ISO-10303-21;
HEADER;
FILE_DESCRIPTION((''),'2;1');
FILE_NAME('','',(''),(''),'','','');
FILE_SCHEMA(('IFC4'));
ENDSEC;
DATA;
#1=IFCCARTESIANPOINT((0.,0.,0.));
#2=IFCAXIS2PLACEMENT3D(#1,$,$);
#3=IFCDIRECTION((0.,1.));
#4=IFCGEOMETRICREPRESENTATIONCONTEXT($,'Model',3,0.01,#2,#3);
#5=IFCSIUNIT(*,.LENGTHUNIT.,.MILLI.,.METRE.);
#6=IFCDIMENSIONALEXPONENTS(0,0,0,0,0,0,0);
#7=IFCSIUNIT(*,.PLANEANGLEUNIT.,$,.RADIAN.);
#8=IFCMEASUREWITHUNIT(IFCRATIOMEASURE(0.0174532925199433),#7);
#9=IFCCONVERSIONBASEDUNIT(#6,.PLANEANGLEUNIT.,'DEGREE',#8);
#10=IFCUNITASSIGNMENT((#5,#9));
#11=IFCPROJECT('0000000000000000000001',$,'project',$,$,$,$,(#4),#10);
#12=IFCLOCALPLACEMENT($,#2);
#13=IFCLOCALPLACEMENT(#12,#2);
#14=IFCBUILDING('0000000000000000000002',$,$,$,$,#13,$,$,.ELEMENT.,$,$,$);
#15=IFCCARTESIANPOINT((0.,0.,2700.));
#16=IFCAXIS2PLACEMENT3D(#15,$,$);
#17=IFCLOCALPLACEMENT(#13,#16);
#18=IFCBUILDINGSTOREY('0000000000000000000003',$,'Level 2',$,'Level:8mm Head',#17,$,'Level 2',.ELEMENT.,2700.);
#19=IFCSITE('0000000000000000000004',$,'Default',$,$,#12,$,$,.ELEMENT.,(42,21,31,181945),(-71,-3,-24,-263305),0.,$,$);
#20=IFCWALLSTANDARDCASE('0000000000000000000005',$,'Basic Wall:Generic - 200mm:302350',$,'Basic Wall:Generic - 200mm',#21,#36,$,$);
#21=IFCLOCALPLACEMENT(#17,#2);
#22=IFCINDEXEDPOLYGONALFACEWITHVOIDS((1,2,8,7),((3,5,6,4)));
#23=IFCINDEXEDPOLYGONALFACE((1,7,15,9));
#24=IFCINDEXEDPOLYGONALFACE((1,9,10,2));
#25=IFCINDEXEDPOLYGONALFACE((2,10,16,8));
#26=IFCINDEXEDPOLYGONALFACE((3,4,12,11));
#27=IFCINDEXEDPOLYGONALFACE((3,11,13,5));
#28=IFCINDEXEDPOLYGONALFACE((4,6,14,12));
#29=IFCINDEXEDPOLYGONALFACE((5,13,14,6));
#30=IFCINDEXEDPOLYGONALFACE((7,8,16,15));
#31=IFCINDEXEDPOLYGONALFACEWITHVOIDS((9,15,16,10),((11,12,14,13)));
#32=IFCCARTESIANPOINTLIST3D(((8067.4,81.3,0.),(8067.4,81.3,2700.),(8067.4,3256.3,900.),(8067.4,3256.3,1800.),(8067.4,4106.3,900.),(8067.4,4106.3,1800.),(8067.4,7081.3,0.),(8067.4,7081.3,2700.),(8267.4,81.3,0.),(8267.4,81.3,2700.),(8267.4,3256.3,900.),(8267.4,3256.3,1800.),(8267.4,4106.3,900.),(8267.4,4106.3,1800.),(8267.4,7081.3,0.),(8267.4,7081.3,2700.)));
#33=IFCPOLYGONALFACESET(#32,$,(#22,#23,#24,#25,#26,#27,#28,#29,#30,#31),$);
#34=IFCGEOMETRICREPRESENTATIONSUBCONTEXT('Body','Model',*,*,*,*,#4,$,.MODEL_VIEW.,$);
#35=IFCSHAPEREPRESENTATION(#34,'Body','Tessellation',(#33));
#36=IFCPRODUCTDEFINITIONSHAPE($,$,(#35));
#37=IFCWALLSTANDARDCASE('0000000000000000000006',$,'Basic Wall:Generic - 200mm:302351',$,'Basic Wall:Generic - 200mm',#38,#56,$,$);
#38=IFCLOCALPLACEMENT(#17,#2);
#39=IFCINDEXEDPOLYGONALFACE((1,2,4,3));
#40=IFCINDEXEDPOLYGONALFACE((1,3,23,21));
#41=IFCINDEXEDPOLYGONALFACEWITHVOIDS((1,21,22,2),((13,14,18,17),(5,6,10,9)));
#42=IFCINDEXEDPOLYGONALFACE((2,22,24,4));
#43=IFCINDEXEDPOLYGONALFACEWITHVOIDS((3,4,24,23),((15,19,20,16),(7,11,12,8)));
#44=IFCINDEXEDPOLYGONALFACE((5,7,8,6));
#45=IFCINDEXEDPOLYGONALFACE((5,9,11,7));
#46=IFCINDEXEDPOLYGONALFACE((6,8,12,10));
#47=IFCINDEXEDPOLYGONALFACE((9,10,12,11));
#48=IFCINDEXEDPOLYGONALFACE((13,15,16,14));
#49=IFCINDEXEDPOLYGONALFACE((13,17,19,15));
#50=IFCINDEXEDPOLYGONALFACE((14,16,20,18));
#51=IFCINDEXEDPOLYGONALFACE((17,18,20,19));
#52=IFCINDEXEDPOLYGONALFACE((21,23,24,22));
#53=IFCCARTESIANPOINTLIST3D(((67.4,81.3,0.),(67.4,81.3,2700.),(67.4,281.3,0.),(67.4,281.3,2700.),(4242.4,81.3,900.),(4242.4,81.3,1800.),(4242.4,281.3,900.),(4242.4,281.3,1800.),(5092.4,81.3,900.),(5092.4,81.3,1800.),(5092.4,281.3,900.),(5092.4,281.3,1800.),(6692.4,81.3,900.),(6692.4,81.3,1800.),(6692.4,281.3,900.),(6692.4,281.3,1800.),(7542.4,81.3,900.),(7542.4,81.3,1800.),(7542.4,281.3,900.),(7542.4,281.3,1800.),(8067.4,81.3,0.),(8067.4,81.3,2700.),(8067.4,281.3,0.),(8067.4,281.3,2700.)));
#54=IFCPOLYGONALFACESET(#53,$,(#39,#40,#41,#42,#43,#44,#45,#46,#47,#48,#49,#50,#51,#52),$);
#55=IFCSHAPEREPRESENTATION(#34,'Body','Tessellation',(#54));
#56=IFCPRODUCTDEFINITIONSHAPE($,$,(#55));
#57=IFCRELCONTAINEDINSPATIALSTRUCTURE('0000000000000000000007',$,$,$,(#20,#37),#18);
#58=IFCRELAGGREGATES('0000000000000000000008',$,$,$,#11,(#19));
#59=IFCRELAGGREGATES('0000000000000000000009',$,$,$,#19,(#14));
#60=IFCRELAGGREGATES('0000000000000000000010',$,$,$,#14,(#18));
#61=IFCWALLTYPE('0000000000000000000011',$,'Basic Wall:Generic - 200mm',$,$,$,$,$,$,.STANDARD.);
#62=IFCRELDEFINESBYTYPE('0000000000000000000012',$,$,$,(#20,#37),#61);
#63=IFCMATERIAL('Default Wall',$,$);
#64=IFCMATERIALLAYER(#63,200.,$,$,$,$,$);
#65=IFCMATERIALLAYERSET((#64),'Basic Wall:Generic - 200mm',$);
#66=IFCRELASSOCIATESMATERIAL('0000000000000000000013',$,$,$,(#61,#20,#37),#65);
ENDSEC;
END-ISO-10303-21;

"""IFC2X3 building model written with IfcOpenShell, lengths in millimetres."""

from ifc_helpers import new_model, entity, si_unit, converted_unit, direction, frame, frame_2d, origin, place, context, subcontext, project, spatial, rectangle, extrude, material, layer, layer_set, layer_usage, type_object, element, save


model = new_model("IFC2X3")

# Units and contexts
model_context = context("Model", 3, precision=0.01, world=origin(), true_north=direction((0.0, 1.0)))
body_context = subcontext(model_context, "Body", "Model", "MODEL_VIEW")
ifc_project = project(units=[si_unit("LENGTHUNIT", "METRE", prefix="MILLI"), converted_unit("PLANEANGLEUNIT", "DEGREE", entity("IfcRatioMeasure", 0.0174532925199433), si_unit("PLANEANGLEUNIT", "RADIAN"), dimensions=[0, 0, 0, 0, 0, 0, 0])], contexts=[model_context])

# Site, building, storey
site_placement = place(None, origin())
site = spatial("IfcSite", under=ifc_project, at=site_placement, Name="Default", CompositionType="ELEMENT", RefLatitude=(42, 21, 31, 181945), RefLongitude=(-71, -3, -24, -263305), RefElevation=0.0)
building_placement = place(site_placement, origin())
building = spatial("IfcBuilding", under=site, at=building_placement, CompositionType="ELEMENT")
storey_placement = place(building_placement, frame((0.0, 0.0, 2700.0)))
storey = spatial("IfcBuildingStorey", under=building, at=storey_placement, Name="Level 2", ObjectType="Level:8mm Head", LongName="Level 2", CompositionType="ELEMENT", Elevation=2700.0)

# Wall, opening
ifc_material_1 = material(Name="Default Wall")
ifc_layer = layer(ifc_material_1, 200.0)
ifc_layer_set = layer_set([ifc_layer], Name="Basic Wall:Generic - 200mm")
ifc_layer_usage_1 = layer_usage(ifc_layer_set, "AXIS2", "NEGATIVE", 100.0)
wall_type = type_object("IfcWallType", Name="Basic Wall:Generic - 200mm", PredefinedType="STANDARD", material=ifc_layer_set)
wall_1_placement = place(storey_placement, frame((8167.4, 7081.3, 0.0), z_axis=(0.0, 0.0, 1.0), x_axis=(0.0, -1.0, 0.0)))
wall_1 = element("IfcWallStandardCase", 1, at=wall_1_placement, inside=storey, type_object=wall_type, material=ifc_layer_usage_1, Name="Basic Wall:Generic - 200mm:302350", ObjectType="Basic Wall:Generic - 200mm", context=body_context, shape_type="SweptSolid", body=[
    extrude(rectangle(XDim=7000.0, YDim=200.0, at=frame_2d((3500.0, 0.0), x_axis=(-1.0, 0.0))), origin(), (0.0, 0.0, 1.0), 2700.0),
])
opening_1_placement = place(wall_1_placement, frame((3825.0, 100.0, 900.0)))
element("IfcOpeningElement", 2, at=opening_1_placement, cuts=wall_1, ObjectType="Opening", context=body_context, shape_type="SweptSolid", body=[
    extrude(rectangle(XDim=900.0, YDim=850.0, at=frame_2d((450.0, 425.0), x_axis=(-1.0, 0.0))), frame((0.0, 0.0, 0.0), z_axis=(0.0, -1.0, 0.0), x_axis=(0.0, 0.0, 1.0)), (0.0, 0.0, 1.0), 200.0),
])

# Wall, openings
ifc_layer_usage_2 = layer_usage(ifc_layer_set, "AXIS2", "NEGATIVE", 100.0)
wall_2_placement = place(storey_placement, frame((8067.4, 181.3, 0.0), z_axis=(0.0, 0.0, 1.0), x_axis=(-1.0, 0.0, 0.0)))
wall_2 = element("IfcWallStandardCase", 3, at=wall_2_placement, inside=storey, type_object=wall_type, material=ifc_layer_usage_2, Name="Basic Wall:Generic - 200mm:302351", ObjectType="Basic Wall:Generic - 200mm", context=body_context, shape_type="SweptSolid", body=[
    extrude(rectangle(XDim=8000.0, YDim=200.0, at=frame_2d((4000.0, 0.0), x_axis=(-1.0, 0.0))), origin(), (0.0, 0.0, 1.0), 2700.0),
])
opening_2_placement = place(wall_2_placement, frame((1375.0, 100.0, 900.0)))
element("IfcOpeningElement", 4, at=opening_2_placement, cuts=wall_2, ObjectType="Opening", context=body_context, shape_type="SweptSolid", body=[
    extrude(rectangle(XDim=900.0, YDim=850.0, at=frame_2d((450.0, 425.0), x_axis=(-1.0, 0.0))), frame((0.0, 0.0, 0.0), z_axis=(0.0, -1.0, 0.0), x_axis=(0.0, 0.0, 1.0)), (0.0, 0.0, 1.0), 200.0),
])
opening_3_placement = place(wall_2_placement, frame((3825.0, 100.0, 900.0)))
element("IfcOpeningElement", 5, at=opening_3_placement, cuts=wall_2, ObjectType="Opening", context=body_context, shape_type="SweptSolid", body=[
    extrude(rectangle(XDim=900.0, YDim=850.0, at=frame_2d((450.0, 425.0), x_axis=(-1.0, 0.0))), frame((0.0, 0.0, 0.0), z_axis=(0.0, -1.0, 0.0), x_axis=(0.0, 0.0, 1.0)), (0.0, 0.0, 1.0), 200.0),
])

save(model, "model.ifc")
